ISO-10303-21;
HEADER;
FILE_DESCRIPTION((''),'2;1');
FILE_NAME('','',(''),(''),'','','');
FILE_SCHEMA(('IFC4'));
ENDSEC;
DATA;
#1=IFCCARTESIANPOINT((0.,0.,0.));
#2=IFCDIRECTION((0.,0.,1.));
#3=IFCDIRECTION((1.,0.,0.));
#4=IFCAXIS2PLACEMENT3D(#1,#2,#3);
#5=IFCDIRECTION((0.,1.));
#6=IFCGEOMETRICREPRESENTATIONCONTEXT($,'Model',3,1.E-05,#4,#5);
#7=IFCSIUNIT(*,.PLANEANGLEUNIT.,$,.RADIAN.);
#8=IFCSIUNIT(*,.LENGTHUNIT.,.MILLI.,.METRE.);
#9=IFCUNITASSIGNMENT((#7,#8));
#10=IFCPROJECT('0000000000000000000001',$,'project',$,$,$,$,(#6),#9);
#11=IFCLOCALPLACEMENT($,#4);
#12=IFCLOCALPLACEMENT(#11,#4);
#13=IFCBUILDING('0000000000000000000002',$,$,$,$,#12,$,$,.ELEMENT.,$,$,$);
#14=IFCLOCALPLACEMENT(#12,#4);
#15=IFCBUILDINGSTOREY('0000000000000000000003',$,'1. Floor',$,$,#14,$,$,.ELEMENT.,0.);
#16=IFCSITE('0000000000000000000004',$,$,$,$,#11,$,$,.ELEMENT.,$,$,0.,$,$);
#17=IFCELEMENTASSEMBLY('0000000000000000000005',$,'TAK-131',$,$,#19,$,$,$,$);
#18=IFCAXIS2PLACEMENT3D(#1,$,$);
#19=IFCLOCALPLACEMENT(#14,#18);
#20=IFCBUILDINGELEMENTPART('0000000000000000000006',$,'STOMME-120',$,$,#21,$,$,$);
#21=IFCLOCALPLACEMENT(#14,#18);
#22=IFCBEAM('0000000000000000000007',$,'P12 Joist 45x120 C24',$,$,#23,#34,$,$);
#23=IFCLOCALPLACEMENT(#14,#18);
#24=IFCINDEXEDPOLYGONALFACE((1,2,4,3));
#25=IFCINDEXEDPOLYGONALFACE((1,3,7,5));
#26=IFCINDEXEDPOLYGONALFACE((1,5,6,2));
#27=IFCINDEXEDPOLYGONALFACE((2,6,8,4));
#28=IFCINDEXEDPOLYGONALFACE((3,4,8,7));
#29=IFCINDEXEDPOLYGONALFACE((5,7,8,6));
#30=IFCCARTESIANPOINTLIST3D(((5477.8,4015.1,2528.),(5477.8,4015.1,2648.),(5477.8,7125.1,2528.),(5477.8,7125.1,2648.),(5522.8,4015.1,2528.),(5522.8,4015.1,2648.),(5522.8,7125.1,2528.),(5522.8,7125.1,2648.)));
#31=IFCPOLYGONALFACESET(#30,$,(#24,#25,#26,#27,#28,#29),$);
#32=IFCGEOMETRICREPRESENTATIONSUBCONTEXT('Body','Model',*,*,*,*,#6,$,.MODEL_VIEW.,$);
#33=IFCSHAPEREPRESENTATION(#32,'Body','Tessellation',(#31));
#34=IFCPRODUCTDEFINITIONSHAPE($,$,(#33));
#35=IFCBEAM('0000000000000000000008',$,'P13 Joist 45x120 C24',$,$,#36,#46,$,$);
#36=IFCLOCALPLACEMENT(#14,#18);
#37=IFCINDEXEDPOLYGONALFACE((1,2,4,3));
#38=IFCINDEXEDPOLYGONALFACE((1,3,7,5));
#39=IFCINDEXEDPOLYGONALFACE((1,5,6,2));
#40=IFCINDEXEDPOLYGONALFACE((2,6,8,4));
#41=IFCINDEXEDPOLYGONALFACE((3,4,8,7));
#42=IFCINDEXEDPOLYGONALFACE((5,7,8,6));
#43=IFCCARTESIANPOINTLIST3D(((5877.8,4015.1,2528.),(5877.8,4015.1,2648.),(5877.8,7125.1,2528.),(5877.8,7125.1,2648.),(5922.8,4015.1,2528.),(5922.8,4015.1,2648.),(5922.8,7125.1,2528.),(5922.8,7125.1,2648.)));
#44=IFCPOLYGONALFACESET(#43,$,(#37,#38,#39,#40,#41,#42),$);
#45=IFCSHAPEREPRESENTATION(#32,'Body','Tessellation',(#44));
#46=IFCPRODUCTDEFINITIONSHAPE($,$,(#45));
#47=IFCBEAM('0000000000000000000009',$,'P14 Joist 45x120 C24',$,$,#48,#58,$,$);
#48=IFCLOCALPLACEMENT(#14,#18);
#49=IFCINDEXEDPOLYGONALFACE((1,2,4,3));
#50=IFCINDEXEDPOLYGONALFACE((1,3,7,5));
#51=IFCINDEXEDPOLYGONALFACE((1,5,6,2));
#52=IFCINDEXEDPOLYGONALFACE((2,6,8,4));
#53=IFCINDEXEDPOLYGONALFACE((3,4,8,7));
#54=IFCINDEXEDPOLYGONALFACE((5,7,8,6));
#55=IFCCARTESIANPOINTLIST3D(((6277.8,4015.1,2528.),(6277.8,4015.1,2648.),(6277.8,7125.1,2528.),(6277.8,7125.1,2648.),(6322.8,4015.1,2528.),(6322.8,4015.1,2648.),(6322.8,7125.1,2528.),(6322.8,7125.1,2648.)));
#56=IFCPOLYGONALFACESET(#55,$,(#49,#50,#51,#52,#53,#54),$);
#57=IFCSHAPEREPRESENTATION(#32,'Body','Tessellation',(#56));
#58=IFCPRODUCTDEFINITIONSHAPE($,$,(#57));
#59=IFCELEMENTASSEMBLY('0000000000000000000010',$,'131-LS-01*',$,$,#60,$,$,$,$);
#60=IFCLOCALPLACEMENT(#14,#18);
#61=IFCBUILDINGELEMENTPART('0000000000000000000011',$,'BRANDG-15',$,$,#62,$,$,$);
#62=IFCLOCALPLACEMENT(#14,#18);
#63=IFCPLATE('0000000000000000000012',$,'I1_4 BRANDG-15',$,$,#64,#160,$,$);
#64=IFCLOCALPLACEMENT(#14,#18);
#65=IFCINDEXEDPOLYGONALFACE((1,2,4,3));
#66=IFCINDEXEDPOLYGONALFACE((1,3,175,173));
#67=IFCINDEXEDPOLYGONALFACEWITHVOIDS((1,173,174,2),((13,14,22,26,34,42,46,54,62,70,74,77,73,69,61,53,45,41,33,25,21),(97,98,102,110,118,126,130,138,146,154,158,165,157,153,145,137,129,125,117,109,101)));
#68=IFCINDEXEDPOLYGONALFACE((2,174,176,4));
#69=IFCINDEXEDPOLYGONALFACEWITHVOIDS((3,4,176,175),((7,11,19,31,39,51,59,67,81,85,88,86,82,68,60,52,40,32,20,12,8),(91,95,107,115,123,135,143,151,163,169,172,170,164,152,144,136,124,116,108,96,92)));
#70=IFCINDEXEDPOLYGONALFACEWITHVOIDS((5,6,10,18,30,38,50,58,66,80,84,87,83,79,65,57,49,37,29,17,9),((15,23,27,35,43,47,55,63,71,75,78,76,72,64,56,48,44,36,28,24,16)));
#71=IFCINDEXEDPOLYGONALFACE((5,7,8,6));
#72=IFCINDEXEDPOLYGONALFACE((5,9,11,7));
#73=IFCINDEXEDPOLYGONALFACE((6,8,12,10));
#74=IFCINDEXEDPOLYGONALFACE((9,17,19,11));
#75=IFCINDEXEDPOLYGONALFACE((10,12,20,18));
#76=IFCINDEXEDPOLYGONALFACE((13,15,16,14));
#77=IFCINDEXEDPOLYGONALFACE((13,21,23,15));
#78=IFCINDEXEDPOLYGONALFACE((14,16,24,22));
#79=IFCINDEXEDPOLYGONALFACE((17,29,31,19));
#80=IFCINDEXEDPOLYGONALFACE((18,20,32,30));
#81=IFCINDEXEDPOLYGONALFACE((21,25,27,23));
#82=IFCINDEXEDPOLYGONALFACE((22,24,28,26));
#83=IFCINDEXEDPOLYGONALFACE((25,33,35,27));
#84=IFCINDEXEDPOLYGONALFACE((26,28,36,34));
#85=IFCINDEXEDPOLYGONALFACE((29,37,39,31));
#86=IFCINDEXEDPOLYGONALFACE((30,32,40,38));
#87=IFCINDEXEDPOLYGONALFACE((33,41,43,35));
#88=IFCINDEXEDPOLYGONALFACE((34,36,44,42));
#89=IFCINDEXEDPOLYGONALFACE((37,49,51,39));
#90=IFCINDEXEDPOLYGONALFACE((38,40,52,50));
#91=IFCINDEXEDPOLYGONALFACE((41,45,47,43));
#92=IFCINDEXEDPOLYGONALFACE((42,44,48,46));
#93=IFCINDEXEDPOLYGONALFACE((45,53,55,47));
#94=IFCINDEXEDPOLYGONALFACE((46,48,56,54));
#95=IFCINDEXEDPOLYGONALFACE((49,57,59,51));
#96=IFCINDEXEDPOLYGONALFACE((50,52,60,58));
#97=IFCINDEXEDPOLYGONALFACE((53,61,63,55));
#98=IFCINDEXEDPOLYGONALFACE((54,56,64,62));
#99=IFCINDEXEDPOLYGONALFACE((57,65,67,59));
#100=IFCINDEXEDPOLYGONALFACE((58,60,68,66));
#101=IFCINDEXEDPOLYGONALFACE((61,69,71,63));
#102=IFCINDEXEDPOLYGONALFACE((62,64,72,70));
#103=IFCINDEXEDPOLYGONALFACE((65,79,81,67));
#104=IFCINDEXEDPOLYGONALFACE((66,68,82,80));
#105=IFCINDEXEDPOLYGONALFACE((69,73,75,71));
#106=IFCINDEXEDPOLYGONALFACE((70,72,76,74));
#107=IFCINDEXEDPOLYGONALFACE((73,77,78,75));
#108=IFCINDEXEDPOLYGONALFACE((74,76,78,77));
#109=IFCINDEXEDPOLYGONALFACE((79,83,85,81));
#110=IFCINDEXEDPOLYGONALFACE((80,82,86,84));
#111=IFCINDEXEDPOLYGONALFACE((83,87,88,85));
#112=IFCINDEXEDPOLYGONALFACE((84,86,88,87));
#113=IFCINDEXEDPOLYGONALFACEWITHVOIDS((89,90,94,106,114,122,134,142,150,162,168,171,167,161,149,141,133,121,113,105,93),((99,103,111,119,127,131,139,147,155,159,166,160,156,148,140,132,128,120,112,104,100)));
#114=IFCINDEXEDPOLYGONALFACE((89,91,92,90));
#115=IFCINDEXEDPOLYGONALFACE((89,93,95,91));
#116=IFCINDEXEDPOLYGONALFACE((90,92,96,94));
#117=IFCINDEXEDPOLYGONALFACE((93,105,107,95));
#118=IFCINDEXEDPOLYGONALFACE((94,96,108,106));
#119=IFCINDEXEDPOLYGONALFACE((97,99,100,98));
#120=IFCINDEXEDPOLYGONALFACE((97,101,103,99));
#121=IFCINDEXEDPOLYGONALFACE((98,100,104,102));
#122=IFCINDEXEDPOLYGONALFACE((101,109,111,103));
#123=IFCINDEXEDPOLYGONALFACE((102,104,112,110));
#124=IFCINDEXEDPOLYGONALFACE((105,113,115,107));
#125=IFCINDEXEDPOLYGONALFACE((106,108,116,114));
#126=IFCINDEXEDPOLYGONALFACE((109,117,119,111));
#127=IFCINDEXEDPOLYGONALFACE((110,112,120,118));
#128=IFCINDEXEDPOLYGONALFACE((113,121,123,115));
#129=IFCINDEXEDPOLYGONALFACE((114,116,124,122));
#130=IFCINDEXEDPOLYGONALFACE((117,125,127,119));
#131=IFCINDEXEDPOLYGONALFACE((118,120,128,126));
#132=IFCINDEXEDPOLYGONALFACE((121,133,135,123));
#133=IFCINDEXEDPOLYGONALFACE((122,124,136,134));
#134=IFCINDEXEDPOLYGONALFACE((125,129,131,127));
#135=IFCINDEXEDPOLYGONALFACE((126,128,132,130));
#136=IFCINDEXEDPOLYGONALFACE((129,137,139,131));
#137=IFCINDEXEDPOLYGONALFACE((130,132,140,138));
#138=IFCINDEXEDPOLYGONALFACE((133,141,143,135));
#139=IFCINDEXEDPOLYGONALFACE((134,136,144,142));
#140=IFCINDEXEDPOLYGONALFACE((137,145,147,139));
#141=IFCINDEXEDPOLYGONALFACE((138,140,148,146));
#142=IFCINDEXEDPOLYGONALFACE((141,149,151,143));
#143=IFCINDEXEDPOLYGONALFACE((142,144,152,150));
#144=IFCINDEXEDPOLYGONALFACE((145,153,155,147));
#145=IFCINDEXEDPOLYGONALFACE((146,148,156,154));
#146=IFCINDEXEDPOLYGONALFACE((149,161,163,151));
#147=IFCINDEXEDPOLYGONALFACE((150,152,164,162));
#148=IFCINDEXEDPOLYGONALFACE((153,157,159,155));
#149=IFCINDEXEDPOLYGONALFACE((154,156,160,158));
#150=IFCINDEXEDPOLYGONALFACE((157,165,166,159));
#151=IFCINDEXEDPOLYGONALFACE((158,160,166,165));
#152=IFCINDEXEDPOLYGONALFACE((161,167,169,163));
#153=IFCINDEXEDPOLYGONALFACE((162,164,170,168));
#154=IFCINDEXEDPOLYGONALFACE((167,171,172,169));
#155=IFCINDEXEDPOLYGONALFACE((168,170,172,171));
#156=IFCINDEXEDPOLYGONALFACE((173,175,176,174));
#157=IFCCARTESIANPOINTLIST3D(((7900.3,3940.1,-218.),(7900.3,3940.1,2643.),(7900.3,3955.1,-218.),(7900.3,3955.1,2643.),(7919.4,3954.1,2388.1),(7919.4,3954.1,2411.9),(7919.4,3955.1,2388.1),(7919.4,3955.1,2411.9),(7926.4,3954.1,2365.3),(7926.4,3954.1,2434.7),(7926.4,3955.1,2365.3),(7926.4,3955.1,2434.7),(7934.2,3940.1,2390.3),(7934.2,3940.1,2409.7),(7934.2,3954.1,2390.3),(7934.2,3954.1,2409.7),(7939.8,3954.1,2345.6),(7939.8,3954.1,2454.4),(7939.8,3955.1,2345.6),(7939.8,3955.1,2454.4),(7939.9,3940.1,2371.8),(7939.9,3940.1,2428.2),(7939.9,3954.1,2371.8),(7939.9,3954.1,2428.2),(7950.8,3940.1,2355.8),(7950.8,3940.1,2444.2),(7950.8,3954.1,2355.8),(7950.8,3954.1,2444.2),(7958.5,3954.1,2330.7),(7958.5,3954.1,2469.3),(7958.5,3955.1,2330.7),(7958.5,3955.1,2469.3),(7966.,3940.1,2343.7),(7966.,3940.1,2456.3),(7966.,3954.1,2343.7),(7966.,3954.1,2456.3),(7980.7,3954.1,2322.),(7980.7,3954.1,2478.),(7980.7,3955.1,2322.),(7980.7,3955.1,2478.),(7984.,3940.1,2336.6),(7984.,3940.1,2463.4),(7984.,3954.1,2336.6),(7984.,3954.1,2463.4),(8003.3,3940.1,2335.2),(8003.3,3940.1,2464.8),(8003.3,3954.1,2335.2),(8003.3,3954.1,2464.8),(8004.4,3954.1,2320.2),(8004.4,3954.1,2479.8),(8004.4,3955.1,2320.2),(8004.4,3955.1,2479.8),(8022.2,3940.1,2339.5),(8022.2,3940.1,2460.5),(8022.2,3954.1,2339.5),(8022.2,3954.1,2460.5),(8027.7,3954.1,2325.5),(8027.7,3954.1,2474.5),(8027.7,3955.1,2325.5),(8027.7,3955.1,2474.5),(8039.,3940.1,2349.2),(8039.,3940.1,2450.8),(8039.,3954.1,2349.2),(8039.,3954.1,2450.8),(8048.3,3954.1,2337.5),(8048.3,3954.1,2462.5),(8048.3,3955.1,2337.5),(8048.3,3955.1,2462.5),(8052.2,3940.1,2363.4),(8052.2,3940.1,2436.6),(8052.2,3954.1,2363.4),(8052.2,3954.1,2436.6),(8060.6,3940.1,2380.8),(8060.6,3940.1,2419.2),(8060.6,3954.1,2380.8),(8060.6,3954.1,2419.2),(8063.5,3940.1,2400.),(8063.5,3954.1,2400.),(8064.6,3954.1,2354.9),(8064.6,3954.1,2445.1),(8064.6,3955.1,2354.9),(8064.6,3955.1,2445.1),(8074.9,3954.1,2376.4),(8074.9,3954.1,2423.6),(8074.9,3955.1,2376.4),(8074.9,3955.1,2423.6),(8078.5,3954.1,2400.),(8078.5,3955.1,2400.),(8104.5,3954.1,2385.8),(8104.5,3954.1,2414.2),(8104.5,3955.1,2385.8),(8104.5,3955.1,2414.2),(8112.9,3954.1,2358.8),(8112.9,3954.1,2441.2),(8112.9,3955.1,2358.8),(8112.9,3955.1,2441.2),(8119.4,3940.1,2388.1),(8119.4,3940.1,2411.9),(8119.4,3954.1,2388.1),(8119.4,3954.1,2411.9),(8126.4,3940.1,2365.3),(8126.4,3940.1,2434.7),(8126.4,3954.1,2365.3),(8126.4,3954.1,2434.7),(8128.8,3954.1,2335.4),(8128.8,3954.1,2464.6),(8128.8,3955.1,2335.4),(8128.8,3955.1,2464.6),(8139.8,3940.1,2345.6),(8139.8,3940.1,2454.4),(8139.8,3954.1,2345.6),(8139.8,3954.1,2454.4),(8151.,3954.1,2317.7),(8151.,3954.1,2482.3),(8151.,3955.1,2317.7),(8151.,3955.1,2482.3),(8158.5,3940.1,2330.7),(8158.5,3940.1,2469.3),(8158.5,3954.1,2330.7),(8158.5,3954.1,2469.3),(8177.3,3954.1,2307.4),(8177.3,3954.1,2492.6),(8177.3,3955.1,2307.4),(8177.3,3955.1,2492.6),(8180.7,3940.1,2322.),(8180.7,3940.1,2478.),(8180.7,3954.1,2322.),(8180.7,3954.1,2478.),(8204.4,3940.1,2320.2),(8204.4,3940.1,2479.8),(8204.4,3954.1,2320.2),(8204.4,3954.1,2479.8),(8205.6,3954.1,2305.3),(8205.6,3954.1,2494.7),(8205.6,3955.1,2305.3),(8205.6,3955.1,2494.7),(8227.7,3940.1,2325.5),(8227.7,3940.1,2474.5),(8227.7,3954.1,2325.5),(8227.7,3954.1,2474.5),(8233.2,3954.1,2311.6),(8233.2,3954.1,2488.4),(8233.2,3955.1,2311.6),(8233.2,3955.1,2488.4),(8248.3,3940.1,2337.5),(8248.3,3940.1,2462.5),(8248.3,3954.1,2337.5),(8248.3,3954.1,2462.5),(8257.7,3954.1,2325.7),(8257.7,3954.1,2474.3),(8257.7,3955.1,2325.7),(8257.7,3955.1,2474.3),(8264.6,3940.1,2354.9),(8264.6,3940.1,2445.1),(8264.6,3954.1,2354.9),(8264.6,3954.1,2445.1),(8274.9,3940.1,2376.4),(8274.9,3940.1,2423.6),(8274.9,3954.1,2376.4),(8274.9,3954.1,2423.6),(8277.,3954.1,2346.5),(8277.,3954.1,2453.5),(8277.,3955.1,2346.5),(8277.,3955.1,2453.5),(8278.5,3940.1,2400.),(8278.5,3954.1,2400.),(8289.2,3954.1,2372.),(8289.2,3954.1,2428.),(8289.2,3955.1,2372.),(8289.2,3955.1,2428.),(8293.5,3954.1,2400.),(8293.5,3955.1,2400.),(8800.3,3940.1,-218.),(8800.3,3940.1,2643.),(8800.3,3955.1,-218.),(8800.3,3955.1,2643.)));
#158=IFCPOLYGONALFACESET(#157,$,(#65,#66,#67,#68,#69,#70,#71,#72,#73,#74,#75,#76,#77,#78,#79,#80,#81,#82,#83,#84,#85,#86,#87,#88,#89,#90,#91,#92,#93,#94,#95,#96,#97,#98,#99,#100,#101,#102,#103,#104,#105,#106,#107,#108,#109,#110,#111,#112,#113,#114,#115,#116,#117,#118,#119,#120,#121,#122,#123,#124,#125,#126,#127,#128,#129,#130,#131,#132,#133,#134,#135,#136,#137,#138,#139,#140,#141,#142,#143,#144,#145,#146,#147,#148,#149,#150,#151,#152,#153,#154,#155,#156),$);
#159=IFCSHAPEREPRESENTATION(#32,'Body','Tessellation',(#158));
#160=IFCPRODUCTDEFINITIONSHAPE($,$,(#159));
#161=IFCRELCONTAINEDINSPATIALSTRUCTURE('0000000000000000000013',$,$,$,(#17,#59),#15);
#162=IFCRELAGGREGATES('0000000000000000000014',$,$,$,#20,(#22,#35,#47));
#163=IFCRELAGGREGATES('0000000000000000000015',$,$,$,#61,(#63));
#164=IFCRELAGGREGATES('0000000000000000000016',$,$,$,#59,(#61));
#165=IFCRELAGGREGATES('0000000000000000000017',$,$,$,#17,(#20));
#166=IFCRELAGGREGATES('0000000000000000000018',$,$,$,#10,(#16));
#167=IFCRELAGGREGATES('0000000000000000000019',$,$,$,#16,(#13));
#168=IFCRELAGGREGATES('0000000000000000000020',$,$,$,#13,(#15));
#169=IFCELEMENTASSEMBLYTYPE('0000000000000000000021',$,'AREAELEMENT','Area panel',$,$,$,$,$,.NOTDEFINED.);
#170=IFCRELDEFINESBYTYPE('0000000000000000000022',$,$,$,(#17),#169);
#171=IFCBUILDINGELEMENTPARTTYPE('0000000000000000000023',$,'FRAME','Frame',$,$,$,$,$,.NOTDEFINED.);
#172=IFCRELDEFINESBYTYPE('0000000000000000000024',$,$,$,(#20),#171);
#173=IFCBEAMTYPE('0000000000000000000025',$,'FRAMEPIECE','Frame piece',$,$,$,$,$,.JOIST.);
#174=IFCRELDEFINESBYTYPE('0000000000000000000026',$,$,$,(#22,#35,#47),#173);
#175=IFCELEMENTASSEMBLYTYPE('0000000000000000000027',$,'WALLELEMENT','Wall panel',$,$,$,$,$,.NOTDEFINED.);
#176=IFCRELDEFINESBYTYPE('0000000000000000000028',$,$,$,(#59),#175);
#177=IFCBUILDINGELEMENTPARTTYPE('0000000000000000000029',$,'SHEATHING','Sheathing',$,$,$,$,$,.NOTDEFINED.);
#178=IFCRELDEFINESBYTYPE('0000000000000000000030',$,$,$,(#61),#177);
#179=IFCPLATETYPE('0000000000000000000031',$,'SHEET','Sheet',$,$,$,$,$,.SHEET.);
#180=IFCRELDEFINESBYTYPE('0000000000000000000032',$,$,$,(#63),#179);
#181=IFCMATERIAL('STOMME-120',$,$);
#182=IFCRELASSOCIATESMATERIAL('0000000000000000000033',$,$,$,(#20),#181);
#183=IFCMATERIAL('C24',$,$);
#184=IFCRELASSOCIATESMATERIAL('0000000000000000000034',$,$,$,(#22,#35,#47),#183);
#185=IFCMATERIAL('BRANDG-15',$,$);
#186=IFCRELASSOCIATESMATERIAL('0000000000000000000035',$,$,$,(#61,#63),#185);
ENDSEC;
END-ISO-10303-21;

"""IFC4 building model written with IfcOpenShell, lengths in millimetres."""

from ifc_helpers import new_model, si_unit, direction, frame, origin_with_axes, origin_2d_with_axis, place, context, subcontext, project, spatial, rectangle, circle, extrude, boolean, material, type_object, element, aggregate, save


model = new_model("IFC4")

# Units and contexts
model_context = context("Model", 3, precision=1e-05, world=origin_with_axes(), true_north=direction((0.0, 1.0)))
body_context = subcontext(model_context, "Body", "Model", "MODEL_VIEW")
ifc_project = project(units=[si_unit("PLANEANGLEUNIT", "RADIAN"), si_unit("LENGTHUNIT", "METRE", prefix="MILLI")], contexts=[model_context])

# Site, building, storey
site_placement = place(None, origin_with_axes())
site = spatial("IfcSite", under=ifc_project, at=site_placement, CompositionType="ELEMENT", RefElevation=0.0)
building_placement = place(site_placement, origin_with_axes())
building = spatial("IfcBuilding", under=site, at=building_placement, CompositionType="ELEMENT")
storey_placement = place(building_placement, origin_with_axes())
storey = spatial("IfcBuildingStorey", under=building, at=storey_placement, Name="1. Floor", CompositionType="ELEMENT", Elevation=0.0)

# Element assembly, building element part, beams
element_assembly_type_1 = type_object("IfcElementAssemblyType", Name="AREAELEMENT", Description="Area panel", PredefinedType="NOTDEFINED")
assembly_1_placement = place(storey_placement, origin_with_axes())
assembly_1 = element("IfcElementAssembly", 1, at=assembly_1_placement, inside=storey, type_object=element_assembly_type_1, Name="TAK-131")
ifc_material_1 = material(Name="STOMME-120")
building_element_part_type_1 = type_object("IfcBuildingElementPartType", Name="FRAME", Description="Frame", PredefinedType="NOTDEFINED")
building_element_part_1_placement = place(storey_placement, origin_with_axes())
building_element_part_1 = element("IfcBuildingElementPart", 2, at=building_element_part_1_placement, type_object=building_element_part_type_1, material=ifc_material_1, Name="STOMME-120")
ifc_material_2 = material(Name="C24")
beam_type = type_object("IfcBeamType", Name="FRAMEPIECE", Description="Frame piece", PredefinedType="JOIST")
beam_1_placement = place(storey_placement, frame((5500.3, 7125.1, 2588.0), z_axis=(0.0, -1.0, 0.0), x_axis=(1.0, 0.0, 0.0)))
beam_1 = element("IfcBeam", 3, at=beam_1_placement, type_object=beam_type, material=ifc_material_2, Name="P12 Joist 45x120 C24", context=body_context, shape_type="SweptSolid", body=[
    extrude(rectangle(XDim=45.0, YDim=120.0, at=origin_2d_with_axis()), origin_with_axes(), (0.0, 0.0, 1.0), 3110.0),
])
beam_2_placement = place(storey_placement, frame((5900.3, 7125.1, 2588.0), z_axis=(0.0, -1.0, 0.0), x_axis=(1.0, 0.0, 0.0)))
beam_2 = element("IfcBeam", 4, at=beam_2_placement, type_object=beam_type, material=ifc_material_2, Name="P13 Joist 45x120 C24", context=body_context, shape_type="SweptSolid", body=[
    extrude(rectangle(XDim=45.0, YDim=120.0, at=origin_2d_with_axis()), origin_with_axes(), (0.0, 0.0, 1.0), 3110.0),
])
beam_3_placement = place(storey_placement, frame((6300.3, 7125.1, 2588.0), z_axis=(0.0, -1.0, 0.0), x_axis=(1.0, 0.0, 0.0)))
beam_3 = element("IfcBeam", 5, at=beam_3_placement, type_object=beam_type, material=ifc_material_2, Name="P14 Joist 45x120 C24", context=body_context, shape_type="SweptSolid", body=[
    extrude(rectangle(XDim=45.0, YDim=120.0, at=origin_2d_with_axis()), origin_with_axes(), (0.0, 0.0, 1.0), 3110.0),
])
aggregate(building_element_part_1, [beam_1, beam_2, beam_3])

# Element assembly, building element part, plate
element_assembly_type_2 = type_object("IfcElementAssemblyType", Name="WALLELEMENT", Description="Wall panel", PredefinedType="NOTDEFINED")
assembly_2_placement = place(storey_placement, origin_with_axes())
assembly_2 = element("IfcElementAssembly", 6, at=assembly_2_placement, inside=storey, type_object=element_assembly_type_2, Name="131-LS-01*")
ifc_material_3 = material(Name="BRANDG-15")
building_element_part_type_2 = type_object("IfcBuildingElementPartType", Name="SHEATHING", Description="Sheathing", PredefinedType="NOTDEFINED")
building_element_part_2_placement = place(storey_placement, origin_with_axes())
building_element_part_2 = element("IfcBuildingElementPart", 7, at=building_element_part_2_placement, type_object=building_element_part_type_2, material=ifc_material_3, Name="BRANDG-15")
plate_type_1 = type_object("IfcPlateType", Name="SHEET", Description="Sheet", PredefinedType="SHEET")
plate_1_placement = place(storey_placement, frame((8200.3, 3940.1, 4782.0), z_axis=(0.0, -1.0, 0.0), x_axis=(1.0, 0.0, 0.0)))
plate_1 = element("IfcPlate", 8, at=plate_1_placement, type_object=plate_type_1, material=ifc_material_3, Name="I1_4 BRANDG-15", context=body_context, shape_type="CSG", body=[
    boolean("DIFFERENCE", boolean("DIFFERENCE", boolean("DIFFERENCE", boolean("DIFFERENCE", extrude(rectangle(XDim=15.0, YDim=900.0, at=origin_2d_with_axis()), frame((150.0, -5000.0, -7.5), z_axis=(0.0, 1.0, 0.0), x_axis=(0.0, 0.0, 1.0)), (0.0, 0.0, 1.0), 2861.0), extrude(circle(Radius=65.0, at=origin_2d_with_axis()), frame((-201.9, -2382.0, -31.0), z_axis=(0.0, 0.0, -1.0), x_axis=(1.0, 0.0, 0.0)), (0.0, 0.0, -1.0), 64.5)), extrude(circle(Radius=80.0, at=origin_2d_with_axis()), frame((-1.9, -2382.0, -31.0), z_axis=(0.0, 0.0, -1.0), x_axis=(1.0, 0.0, 0.0)), (0.0, 0.0, -1.0), 64.5)), extrude(circle(Radius=95.0, at=origin_2d_with_axis()), frame((-1.9, -2382.0, -31.0), z_axis=(0.0, 0.0, -1.0), x_axis=(1.0, 0.0, 0.0)), (0.0, 0.0, -1.0), 17.0)), extrude(circle(Radius=80.0, at=origin_2d_with_axis()), frame((-201.9, -2382.0, -31.0), z_axis=(0.0, 0.0, -1.0), x_axis=(1.0, 0.0, 0.0)), (0.0, 0.0, -1.0), 17.0)),
])
aggregate(building_element_part_2, [plate_1])
aggregate(assembly_2, [building_element_part_2])

aggregate(assembly_1, [building_element_part_1])

save(model, "model.ifc")
